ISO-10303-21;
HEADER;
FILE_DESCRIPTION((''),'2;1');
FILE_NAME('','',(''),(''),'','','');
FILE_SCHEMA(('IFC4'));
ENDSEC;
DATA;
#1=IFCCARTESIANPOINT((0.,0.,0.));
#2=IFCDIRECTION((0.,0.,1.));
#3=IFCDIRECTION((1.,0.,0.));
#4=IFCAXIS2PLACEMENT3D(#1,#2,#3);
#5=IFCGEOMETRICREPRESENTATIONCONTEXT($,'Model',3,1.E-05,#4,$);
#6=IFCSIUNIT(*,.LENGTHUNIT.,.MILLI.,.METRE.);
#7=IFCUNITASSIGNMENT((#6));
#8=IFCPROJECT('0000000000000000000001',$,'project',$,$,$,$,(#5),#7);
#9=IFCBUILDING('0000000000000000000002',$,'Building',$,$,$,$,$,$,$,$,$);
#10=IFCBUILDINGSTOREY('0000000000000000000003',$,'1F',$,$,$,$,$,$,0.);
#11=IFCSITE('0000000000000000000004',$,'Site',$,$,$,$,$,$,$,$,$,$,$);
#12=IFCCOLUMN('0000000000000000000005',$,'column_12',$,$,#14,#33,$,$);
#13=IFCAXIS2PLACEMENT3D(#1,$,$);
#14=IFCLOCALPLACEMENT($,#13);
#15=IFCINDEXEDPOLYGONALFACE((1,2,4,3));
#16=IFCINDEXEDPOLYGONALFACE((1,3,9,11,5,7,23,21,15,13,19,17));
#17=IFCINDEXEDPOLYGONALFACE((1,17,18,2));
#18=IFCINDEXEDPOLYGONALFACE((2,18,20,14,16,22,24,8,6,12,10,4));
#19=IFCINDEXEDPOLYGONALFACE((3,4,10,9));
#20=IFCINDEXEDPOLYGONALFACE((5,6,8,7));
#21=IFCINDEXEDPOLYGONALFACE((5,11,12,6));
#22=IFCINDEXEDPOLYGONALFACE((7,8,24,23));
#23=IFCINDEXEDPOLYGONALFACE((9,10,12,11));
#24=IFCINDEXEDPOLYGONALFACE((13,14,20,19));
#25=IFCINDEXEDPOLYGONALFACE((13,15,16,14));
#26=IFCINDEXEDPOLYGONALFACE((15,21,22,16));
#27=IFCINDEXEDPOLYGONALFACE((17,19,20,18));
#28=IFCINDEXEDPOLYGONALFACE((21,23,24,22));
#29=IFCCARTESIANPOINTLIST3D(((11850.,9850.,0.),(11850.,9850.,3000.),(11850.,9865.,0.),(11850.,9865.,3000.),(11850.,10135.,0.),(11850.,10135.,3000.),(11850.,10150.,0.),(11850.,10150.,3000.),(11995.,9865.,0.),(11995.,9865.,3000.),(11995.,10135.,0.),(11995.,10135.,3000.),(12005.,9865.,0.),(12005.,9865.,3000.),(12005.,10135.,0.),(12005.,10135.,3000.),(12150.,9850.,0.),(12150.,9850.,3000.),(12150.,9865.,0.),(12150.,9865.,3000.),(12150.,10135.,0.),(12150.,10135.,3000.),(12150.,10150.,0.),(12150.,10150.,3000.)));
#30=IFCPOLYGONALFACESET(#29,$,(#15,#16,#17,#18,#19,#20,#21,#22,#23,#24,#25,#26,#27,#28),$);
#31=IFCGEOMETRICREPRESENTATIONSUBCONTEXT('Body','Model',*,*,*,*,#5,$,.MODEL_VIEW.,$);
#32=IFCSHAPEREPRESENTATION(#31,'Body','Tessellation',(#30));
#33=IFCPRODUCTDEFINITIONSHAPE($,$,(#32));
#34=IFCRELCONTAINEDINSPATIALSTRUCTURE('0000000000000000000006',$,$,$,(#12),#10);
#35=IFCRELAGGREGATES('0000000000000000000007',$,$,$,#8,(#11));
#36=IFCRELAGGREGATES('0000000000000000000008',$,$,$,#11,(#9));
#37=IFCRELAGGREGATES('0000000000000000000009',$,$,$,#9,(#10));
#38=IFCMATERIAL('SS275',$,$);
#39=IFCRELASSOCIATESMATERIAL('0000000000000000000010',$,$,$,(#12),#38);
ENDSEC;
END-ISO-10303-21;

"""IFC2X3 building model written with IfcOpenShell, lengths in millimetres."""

from ifc_helpers import new_model, si_unit, frame, origin, origin_with_axes, origin_2d_with_axis, place, context, subcontext, project, spatial, i_section, extrude, material, element, save


model = new_model("IFC2X3")

# Units and contexts
model_context = context("Model", 3, precision=1e-05, world=origin_with_axes())
body_context = subcontext(model_context, "Body", "Model", "MODEL_VIEW")
ifc_project = project(units=[si_unit("LENGTHUNIT", "METRE", prefix="MILLI")], contexts=[model_context])

# Site, building, storey
site = spatial("IfcSite", under=ifc_project, Name="Site")
building = spatial("IfcBuilding", under=site, Name="Building")
storey = spatial("IfcBuildingStorey", under=building, Name="1F", Elevation=0.0)

# Column
ifc_material = material(Name="SS275")
for number, where, z_axis, x_axis, name in (
    (1, (12000.0, 10000.0, 0.0), (0.0, 0.0, 1.0), (1.0, 0.0, 0.0), "column_12"),
):
    element("IfcColumn", number, at=place(None, frame(where, z_axis=z_axis, x_axis=x_axis)), inside=storey, material=ifc_material, Name=name, context=body_context, shape_type="SweptSolid", body=[
        extrude(i_section(OverallWidth=300.0, OverallDepth=300.0, WebThickness=10.0, FlangeThickness=15.0, at=origin_2d_with_axis()), origin(), (0.0, 0.0, 1.0), 3000.0),
    ])

save(model, "model.ifc")
